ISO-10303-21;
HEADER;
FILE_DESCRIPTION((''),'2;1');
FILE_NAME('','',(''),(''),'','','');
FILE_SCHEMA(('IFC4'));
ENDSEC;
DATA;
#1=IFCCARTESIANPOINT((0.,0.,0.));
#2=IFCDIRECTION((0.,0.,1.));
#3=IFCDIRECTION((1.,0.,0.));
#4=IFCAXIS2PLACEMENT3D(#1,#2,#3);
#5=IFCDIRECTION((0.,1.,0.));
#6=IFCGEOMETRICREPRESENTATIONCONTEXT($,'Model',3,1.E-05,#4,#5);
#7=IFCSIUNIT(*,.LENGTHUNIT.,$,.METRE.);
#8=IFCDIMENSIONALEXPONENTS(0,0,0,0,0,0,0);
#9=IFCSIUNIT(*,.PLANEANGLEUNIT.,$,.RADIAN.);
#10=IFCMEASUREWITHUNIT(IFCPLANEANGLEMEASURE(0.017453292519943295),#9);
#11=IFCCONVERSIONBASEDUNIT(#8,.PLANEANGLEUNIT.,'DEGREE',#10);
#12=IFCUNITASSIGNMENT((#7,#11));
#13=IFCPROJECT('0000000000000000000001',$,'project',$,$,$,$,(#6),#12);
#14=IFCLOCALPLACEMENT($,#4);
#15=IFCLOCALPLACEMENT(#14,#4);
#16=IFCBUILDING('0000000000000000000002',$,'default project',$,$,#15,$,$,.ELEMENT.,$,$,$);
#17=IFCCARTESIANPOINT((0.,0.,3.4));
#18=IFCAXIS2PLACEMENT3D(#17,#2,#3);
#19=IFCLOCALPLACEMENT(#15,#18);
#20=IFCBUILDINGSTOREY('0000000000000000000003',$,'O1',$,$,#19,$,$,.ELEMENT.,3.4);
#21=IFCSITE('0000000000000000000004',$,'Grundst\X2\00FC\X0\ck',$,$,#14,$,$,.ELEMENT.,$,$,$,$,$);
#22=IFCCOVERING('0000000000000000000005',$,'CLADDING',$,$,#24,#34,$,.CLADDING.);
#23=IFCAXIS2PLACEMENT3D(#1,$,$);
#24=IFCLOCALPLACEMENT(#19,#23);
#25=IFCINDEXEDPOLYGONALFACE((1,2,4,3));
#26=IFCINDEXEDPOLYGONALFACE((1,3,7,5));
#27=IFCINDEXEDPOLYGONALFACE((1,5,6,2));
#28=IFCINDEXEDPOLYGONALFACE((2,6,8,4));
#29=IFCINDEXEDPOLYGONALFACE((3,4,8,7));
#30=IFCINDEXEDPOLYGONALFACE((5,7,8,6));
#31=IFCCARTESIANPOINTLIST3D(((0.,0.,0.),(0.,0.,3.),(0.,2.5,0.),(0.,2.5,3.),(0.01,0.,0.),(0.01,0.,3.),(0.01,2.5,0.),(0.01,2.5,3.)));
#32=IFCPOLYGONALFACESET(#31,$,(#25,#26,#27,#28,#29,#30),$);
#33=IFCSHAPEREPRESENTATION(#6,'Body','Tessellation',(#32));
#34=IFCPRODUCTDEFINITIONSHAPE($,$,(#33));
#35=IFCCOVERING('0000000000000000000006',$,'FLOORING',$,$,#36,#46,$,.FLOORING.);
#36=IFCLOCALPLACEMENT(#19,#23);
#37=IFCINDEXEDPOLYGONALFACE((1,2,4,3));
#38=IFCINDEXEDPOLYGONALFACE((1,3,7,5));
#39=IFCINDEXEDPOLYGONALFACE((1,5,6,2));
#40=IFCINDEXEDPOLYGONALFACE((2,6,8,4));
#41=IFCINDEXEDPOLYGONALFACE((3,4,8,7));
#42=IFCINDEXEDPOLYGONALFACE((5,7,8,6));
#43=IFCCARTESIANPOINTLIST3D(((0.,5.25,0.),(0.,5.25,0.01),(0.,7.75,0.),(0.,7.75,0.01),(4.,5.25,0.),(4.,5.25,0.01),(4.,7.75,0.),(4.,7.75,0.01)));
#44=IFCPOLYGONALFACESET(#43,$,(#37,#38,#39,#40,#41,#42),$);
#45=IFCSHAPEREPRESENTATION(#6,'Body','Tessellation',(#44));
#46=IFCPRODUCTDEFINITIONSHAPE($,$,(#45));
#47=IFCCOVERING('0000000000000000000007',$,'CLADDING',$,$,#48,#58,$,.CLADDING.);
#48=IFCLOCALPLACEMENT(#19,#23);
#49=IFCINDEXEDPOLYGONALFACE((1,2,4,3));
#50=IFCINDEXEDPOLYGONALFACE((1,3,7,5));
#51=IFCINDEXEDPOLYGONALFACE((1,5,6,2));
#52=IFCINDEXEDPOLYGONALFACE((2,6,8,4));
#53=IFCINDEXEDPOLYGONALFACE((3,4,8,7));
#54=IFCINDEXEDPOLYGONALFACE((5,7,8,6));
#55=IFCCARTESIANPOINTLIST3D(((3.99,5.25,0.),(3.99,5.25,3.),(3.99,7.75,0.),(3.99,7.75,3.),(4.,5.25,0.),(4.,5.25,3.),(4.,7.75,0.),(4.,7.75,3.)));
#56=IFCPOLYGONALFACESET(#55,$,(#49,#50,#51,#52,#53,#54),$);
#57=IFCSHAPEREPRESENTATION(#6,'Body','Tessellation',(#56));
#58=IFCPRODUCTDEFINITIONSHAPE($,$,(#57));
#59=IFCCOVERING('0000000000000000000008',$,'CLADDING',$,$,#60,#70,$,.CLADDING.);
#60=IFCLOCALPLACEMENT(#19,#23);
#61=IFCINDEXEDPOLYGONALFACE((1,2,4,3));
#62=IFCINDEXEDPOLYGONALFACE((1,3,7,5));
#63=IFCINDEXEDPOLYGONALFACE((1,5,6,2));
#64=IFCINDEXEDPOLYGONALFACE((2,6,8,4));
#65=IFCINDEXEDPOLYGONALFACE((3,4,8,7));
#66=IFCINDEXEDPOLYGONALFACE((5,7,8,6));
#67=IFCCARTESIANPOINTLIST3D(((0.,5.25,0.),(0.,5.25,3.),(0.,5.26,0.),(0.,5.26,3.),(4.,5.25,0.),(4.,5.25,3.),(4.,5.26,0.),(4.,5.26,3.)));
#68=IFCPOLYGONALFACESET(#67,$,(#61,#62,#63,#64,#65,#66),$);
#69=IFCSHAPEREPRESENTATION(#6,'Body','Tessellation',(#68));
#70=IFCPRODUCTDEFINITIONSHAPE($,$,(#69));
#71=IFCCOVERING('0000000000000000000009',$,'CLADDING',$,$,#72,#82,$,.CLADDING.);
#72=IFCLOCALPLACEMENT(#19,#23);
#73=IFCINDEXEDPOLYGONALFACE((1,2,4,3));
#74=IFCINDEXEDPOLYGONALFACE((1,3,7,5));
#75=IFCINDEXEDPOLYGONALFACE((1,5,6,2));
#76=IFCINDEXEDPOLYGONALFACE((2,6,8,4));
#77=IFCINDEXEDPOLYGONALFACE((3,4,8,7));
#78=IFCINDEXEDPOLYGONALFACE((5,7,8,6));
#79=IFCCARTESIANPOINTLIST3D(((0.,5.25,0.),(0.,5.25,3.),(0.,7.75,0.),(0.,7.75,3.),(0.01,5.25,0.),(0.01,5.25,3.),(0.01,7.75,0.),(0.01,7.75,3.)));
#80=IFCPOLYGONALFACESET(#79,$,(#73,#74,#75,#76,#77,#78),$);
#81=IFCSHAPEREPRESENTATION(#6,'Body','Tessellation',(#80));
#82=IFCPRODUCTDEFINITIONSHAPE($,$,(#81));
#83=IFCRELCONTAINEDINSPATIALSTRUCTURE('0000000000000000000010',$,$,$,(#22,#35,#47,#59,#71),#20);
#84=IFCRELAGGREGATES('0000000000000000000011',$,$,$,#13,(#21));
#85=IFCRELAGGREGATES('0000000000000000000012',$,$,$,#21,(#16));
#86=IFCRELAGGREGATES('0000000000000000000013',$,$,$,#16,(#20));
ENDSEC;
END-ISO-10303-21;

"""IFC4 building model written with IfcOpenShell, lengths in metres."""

from ifc_helpers import new_model, entity, si_unit, converted_unit, direction, frame, origin_with_axes, place, context, project, spatial, polyline, outline, extrude, element, save


model = new_model("IFC4")

# Units and contexts
model_context = context("Model", 3, precision=1e-05, world=origin_with_axes(), true_north=direction((0.0, 1.0, 0.0)))
ifc_project = project(units=[si_unit("LENGTHUNIT", "METRE"), converted_unit("PLANEANGLEUNIT", "DEGREE", entity("IfcPlaneAngleMeasure", 0.017453292519943295), si_unit("PLANEANGLEUNIT", "RADIAN"), dimensions=[0, 0, 0, 0, 0, 0, 0])], contexts=[model_context])

# Site, building, storey
site_placement = place(None, origin_with_axes())
site = spatial("IfcSite", under=ifc_project, at=site_placement, Name="Grundstück", CompositionType="ELEMENT")
building_placement = place(site_placement, origin_with_axes())
building = spatial("IfcBuilding", under=site, at=building_placement, Name="default project", CompositionType="ELEMENT")
placement_1 = place(building_placement, frame((0.0, 0.0, 3.4), z_axis=(0.0, 0.0, 1.0), x_axis=(1.0, 0.0, 0.0)))
storey = spatial("IfcBuildingStorey", under=building, at=placement_1, Name="O1", CompositionType="ELEMENT", Elevation=3.4)

# Coverings
element("IfcCovering", 1, at=placement_1, inside=storey, Name="CLADDING", PredefinedType="CLADDING", context=model_context, shape_type="SweptSolid", body=[
    extrude(outline(polyline([(0.01, 0.0), (0.01, 2.5), (0.0, 2.5), (0.0, 0.0), (0.01, 0.0)])), origin_with_axes(), (0.0, 0.0, 1.0), 3.0),
])
element("IfcCovering", 2, at=placement_1, inside=storey, Name="FLOORING", PredefinedType="FLOORING", context=model_context, shape_type="SweptSolid", body=[
    extrude(outline(polyline([(4.0, 7.75), (0.0, 7.75), (0.0, 5.25), (4.0, 5.25), (4.0, 7.75)])), origin_with_axes(), (0.0, 0.0, 1.0), 0.01),
])
element("IfcCovering", 3, at=placement_1, inside=storey, Name="CLADDING", PredefinedType="CLADDING", context=model_context, shape_type="SweptSolid", body=[
    extrude(outline(polyline([(3.99, 7.75), (3.99, 5.25), (4.0, 5.25), (4.0, 7.75), (3.99, 7.75)])), origin_with_axes(), (0.0, 0.0, 1.0), 3.0),
])
element("IfcCovering", 4, at=placement_1, inside=storey, Name="CLADDING", PredefinedType="CLADDING", context=model_context, shape_type="SweptSolid", body=[
    extrude(outline(polyline([(4.0, 5.26), (0.0, 5.26), (0.0, 5.25), (4.0, 5.25), (4.0, 5.26)])), origin_with_axes(), (0.0, 0.0, 1.0), 3.0),
])
element("IfcCovering", 5, at=placement_1, inside=storey, Name="CLADDING", PredefinedType="CLADDING", context=model_context, shape_type="SweptSolid", body=[
    extrude(outline(polyline([(0.01, 5.25), (0.01, 7.75), (0.0, 7.75), (0.0, 5.25), (0.01, 5.25)])), origin_with_axes(), (0.0, 0.0, 1.0), 3.0),
])

save(model, "model.ifc")
